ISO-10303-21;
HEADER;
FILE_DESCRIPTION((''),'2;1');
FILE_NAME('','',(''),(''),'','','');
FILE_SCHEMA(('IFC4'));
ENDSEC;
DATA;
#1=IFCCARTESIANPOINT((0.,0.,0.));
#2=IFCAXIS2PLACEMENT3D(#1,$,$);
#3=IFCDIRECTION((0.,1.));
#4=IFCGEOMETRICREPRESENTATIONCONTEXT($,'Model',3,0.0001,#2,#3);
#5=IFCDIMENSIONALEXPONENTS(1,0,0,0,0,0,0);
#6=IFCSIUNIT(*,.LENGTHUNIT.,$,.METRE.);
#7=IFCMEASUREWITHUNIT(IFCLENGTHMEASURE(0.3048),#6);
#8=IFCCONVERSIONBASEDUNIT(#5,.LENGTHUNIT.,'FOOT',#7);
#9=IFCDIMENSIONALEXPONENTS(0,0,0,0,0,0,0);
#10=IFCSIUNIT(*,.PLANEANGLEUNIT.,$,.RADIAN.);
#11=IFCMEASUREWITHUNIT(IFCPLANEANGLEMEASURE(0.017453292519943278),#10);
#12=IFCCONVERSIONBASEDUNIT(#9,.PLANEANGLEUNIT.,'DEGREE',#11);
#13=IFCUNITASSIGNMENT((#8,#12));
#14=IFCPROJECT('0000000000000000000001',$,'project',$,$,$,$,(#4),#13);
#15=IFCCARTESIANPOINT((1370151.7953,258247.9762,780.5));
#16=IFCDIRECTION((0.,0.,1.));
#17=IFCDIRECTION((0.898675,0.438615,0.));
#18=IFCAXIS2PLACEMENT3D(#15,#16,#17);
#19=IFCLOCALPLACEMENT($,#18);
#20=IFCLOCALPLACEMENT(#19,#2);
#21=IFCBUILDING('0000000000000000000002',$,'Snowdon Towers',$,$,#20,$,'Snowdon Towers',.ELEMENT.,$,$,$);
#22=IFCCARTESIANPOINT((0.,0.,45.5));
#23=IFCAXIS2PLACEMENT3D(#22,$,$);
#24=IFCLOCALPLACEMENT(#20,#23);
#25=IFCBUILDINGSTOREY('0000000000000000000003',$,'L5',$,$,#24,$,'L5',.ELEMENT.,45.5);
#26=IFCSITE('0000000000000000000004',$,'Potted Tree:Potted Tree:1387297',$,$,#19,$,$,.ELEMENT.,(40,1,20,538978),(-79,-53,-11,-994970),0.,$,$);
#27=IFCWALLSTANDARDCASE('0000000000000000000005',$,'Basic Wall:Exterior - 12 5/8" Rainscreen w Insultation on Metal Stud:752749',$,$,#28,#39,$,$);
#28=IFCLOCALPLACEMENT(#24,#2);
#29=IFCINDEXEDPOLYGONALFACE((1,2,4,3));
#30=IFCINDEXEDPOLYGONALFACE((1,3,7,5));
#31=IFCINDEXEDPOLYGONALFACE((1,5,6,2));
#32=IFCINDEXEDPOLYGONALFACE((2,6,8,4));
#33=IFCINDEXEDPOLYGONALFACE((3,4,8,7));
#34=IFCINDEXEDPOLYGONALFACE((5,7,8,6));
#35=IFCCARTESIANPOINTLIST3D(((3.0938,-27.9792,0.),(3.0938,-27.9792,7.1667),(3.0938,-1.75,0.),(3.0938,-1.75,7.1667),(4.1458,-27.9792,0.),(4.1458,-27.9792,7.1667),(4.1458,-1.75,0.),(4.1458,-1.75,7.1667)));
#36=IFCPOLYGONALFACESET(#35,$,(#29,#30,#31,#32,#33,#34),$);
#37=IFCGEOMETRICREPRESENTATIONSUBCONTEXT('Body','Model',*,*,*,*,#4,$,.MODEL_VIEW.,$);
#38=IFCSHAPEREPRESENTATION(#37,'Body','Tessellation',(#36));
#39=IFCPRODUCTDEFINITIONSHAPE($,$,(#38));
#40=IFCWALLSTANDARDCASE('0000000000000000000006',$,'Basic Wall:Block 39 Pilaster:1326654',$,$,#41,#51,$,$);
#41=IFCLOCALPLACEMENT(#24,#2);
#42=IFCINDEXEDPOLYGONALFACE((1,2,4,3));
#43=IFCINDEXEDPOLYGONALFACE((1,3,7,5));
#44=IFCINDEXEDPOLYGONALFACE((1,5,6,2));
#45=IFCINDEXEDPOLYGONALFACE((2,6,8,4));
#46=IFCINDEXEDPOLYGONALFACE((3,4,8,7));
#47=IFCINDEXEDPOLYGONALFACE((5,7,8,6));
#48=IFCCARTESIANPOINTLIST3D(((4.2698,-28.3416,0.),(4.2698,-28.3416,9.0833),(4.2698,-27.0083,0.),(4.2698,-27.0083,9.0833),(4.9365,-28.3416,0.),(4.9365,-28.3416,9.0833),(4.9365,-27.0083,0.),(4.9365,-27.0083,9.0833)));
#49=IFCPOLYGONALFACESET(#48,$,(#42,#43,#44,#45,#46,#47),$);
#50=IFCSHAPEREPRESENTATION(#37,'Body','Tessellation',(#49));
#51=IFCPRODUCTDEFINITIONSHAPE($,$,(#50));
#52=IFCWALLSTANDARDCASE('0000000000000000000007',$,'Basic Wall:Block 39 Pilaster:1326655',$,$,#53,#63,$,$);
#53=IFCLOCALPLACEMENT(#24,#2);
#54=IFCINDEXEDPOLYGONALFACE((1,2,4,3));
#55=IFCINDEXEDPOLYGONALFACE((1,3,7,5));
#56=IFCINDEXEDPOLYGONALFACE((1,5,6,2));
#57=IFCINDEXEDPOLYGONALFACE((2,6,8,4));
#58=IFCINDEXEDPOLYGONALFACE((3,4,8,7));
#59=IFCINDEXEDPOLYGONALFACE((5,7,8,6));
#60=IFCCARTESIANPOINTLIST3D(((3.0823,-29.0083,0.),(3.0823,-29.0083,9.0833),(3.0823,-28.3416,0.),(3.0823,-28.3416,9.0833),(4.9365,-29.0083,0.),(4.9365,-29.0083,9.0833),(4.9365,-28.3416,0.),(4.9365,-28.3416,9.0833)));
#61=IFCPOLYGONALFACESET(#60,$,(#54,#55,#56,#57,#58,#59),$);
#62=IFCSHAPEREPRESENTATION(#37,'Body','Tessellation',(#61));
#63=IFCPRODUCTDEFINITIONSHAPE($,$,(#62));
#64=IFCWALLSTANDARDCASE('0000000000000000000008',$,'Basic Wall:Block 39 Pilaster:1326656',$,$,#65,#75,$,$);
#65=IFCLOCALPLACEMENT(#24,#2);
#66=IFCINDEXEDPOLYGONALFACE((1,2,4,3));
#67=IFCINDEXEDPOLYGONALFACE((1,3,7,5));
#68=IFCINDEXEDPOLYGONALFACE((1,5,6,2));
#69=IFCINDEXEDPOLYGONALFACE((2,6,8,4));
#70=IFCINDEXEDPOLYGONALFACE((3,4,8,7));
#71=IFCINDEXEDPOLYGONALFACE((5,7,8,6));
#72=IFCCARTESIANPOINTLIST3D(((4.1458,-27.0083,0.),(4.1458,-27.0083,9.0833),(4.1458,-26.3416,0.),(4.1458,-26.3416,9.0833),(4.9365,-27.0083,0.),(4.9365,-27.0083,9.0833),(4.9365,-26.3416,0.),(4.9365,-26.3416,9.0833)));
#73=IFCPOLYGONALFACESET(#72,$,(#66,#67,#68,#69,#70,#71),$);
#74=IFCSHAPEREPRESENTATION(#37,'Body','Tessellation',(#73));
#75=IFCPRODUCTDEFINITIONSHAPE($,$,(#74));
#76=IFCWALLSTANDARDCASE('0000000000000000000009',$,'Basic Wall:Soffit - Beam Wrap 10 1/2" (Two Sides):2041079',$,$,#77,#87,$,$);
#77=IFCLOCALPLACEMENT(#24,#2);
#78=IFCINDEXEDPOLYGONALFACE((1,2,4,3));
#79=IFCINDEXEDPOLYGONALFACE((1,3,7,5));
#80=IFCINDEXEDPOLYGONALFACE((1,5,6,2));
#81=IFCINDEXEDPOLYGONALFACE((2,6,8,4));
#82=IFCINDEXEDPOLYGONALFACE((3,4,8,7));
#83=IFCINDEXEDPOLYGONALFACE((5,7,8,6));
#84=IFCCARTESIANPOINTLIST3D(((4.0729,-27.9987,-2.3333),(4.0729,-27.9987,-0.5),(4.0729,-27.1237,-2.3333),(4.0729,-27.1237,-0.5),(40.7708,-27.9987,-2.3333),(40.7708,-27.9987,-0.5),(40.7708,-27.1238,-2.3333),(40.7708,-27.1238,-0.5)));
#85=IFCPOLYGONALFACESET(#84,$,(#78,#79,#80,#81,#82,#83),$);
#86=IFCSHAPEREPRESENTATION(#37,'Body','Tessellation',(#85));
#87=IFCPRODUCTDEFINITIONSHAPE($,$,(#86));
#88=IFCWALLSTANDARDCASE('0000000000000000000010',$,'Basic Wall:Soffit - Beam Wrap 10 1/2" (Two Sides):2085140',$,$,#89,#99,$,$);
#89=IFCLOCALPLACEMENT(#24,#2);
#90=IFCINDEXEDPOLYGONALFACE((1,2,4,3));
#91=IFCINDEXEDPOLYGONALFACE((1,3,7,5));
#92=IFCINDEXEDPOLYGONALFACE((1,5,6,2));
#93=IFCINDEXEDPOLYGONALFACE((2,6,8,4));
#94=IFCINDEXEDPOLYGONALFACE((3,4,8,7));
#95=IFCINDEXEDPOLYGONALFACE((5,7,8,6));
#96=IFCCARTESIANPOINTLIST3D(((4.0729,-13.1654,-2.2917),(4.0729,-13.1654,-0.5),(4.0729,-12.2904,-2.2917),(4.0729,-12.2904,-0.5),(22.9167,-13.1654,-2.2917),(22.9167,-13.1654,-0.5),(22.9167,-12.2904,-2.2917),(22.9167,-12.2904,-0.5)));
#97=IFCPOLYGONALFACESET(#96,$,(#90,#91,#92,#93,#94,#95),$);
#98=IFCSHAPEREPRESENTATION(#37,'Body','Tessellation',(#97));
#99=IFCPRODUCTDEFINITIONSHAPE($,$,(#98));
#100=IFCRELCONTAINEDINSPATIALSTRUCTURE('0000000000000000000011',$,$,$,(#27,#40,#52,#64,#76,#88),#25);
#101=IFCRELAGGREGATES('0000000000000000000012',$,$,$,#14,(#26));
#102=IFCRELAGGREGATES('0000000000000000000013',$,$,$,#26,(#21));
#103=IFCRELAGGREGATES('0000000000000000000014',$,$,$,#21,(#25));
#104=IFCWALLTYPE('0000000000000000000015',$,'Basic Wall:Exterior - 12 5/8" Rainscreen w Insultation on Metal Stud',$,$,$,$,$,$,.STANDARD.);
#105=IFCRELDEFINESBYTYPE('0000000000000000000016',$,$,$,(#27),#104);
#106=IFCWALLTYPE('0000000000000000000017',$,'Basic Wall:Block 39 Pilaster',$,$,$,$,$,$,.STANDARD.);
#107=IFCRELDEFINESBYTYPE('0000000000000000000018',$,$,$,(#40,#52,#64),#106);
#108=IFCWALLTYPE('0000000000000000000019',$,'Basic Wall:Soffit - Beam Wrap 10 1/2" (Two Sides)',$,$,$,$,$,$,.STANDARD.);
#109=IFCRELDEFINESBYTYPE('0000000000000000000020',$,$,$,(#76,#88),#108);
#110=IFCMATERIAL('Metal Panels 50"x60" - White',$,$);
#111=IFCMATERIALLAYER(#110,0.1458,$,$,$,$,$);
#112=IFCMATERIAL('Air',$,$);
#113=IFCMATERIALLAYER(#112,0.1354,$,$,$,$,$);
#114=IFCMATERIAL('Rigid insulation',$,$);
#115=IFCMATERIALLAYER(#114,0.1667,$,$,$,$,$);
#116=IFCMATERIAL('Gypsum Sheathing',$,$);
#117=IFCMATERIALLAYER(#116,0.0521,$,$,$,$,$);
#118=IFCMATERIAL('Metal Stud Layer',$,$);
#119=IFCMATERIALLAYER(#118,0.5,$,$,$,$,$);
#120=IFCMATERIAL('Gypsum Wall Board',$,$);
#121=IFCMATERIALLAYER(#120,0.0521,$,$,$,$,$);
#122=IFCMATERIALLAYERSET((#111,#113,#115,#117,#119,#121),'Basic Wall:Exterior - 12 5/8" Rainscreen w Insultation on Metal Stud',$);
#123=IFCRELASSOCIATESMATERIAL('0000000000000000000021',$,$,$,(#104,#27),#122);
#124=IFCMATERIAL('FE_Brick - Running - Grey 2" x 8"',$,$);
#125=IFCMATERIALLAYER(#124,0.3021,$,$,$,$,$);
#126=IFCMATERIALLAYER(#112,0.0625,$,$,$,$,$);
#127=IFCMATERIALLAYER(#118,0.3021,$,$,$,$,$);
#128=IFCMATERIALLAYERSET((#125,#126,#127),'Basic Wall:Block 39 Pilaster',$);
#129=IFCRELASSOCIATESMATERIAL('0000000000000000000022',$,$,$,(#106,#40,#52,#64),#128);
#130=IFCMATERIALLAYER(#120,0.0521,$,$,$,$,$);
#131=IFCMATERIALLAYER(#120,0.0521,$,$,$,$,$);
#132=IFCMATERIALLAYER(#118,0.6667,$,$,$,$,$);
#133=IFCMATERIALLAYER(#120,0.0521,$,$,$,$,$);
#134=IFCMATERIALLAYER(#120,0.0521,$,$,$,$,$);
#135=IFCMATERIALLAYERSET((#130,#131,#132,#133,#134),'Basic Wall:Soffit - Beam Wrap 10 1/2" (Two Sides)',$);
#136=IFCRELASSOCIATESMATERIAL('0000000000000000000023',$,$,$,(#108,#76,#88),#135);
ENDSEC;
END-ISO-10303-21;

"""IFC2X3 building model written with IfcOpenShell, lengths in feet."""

from ifc_helpers import new_model, entity, si_unit, converted_unit, direction, frame, frame_2d, origin, place, context, subcontext, project, spatial, rectangle, extrude, material, layer, layer_set, layer_usage, type_object, element, save


model = new_model("IFC2X3")

# Units and contexts
model_context = context("Model", 3, precision=0.0001, world=origin(), true_north=direction((0.0, 1.0)))
body_context = subcontext(model_context, "Body", "Model", "MODEL_VIEW")
ifc_project = project(units=[converted_unit("LENGTHUNIT", "FOOT", entity("IfcLengthMeasure", 0.3048), si_unit("LENGTHUNIT", "METRE"), dimensions=[1, 0, 0, 0, 0, 0, 0]), converted_unit("PLANEANGLEUNIT", "DEGREE", entity("IfcPlaneAngleMeasure", 0.017453292519943278), si_unit("PLANEANGLEUNIT", "RADIAN"), dimensions=[0, 0, 0, 0, 0, 0, 0])], contexts=[model_context])

# Site, building, storey
site_placement = place(None, frame((1370151.7953, 258247.9762, 780.5), z_axis=(0.0, 0.0, 1.0), x_axis=(0.898675, 0.438615, 0.0)))
site = spatial("IfcSite", under=ifc_project, at=site_placement, Name="Potted Tree:Potted Tree:1387297", CompositionType="ELEMENT", RefLatitude=(40, 1, 20, 538978), RefLongitude=(-79, -53, -11, -994970), RefElevation=0.0)
building_placement = place(site_placement, origin())
building = spatial("IfcBuilding", under=site, at=building_placement, Name="Snowdon Towers", LongName="Snowdon Towers", CompositionType="ELEMENT")
storey_placement = place(building_placement, frame((0.0, 0.0, 45.5)))
storey = spatial("IfcBuildingStorey", under=building, at=storey_placement, Name="L5", LongName="L5", CompositionType="ELEMENT", Elevation=45.5)

# Walls
ifc_material_1 = material(Name="Metal Panels 50\"x60\" - White")
ifc_layer_1 = layer(ifc_material_1, 0.1458)
ifc_material_2 = material(Name="Air")
ifc_layer_2 = layer(ifc_material_2, 0.1354)
ifc_material_3 = material(Name="Rigid insulation")
ifc_layer_3 = layer(ifc_material_3, 0.1667)
ifc_material_4 = material(Name="Gypsum Sheathing")
ifc_layer_4 = layer(ifc_material_4, 0.0521)
ifc_material_5 = material(Name="Metal Stud Layer")
ifc_layer_5 = layer(ifc_material_5, 0.5)
ifc_material_6 = material(Name="Gypsum Wall Board")
ifc_layer_6 = layer(ifc_material_6, 0.0521)
ifc_layer_set_1 = layer_set([ifc_layer_1, ifc_layer_2, ifc_layer_3, ifc_layer_4, ifc_layer_5, ifc_layer_6], Name="Basic Wall:Exterior - 12 5/8\" Rainscreen w Insultation on Metal Stud")
ifc_layer_usage_1 = layer_usage(ifc_layer_set_1, "AXIS2", "POSITIVE", -0.526)
wall_type_1 = type_object("IfcWallType", Name="Basic Wall:Exterior - 12 5/8\" Rainscreen w Insultation on Metal Stud", PredefinedType="STANDARD", material=ifc_layer_set_1)
wall_1_placement = place(storey_placement, frame((3.6198, -27.9792, 0.0), z_axis=(0.0, 0.0, 1.0), x_axis=(0.0, 1.0, 0.0)))
element("IfcWallStandardCase", 1, at=wall_1_placement, inside=storey, type_object=wall_type_1, material=ifc_layer_usage_1, Name="Basic Wall:Exterior - 12 5/8\" Rainscreen w Insultation on Metal Stud:752749", context=body_context, shape_type="SweptSolid", body=[
    extrude(rectangle(XDim=26.2292, YDim=1.0521, at=frame_2d((13.1146, 0.0), x_axis=(-1.0, 0.0))), origin(), (0.0, 0.0, 1.0), 7.1667),
])
ifc_material_7 = material(Name="FE_Brick - Running - Grey 2\" x 8\"")
ifc_layer_7 = layer(ifc_material_7, 0.3021)
ifc_layer_8 = layer(ifc_material_2, 0.0625)
ifc_layer_9 = layer(ifc_material_5, 0.3021)
ifc_layer_set_2 = layer_set([ifc_layer_7, ifc_layer_8, ifc_layer_9], Name="Basic Wall:Block 39 Pilaster")
ifc_layer_usage_2 = layer_usage(ifc_layer_set_2, "AXIS2", "NEGATIVE", 0.3333)
wall_type_2 = type_object("IfcWallType", Name="Basic Wall:Block 39 Pilaster", PredefinedType="STANDARD", material=ifc_layer_set_2)
wall_2_placement = place(storey_placement, frame((4.6031, -27.0083, 0.0), z_axis=(0.0, 0.0, 1.0), x_axis=(0.0, -1.0, 0.0)))
element("IfcWallStandardCase", 2, at=wall_2_placement, inside=storey, type_object=wall_type_2, material=ifc_layer_usage_2, Name="Basic Wall:Block 39 Pilaster:1326654", context=body_context, shape_type="SweptSolid", body=[
    extrude(rectangle(XDim=1.3333, YDim=0.6667, at=frame_2d((0.6667, 0.0), x_axis=(-1.0, 0.0))), origin(), (0.0, 0.0, 1.0), 9.0833),
])
ifc_layer_usage_3 = layer_usage(ifc_layer_set_2, "AXIS2", "NEGATIVE", 0.3333)
wall_3_placement = place(storey_placement, frame((4.9365, -28.675, 0.0), z_axis=(0.0, 0.0, 1.0), x_axis=(-1.0, 0.0, 0.0)))
element("IfcWallStandardCase", 3, at=wall_3_placement, inside=storey, type_object=wall_type_2, material=ifc_layer_usage_3, Name="Basic Wall:Block 39 Pilaster:1326655", context=body_context, shape_type="SweptSolid", body=[
    extrude(rectangle(XDim=1.8542, YDim=0.6667, at=frame_2d((0.9271, 0.0), x_axis=(-1.0, 0.0))), origin(), (0.0, 0.0, 1.0), 9.0833),
])
ifc_layer_usage_4 = layer_usage(ifc_layer_set_2, "AXIS2", "POSITIVE", -0.3333)
wall_4_placement = place(storey_placement, frame((4.9365, -26.675, 0.0), z_axis=(0.0, 0.0, 1.0), x_axis=(-1.0, 0.0, 0.0)))
element("IfcWallStandardCase", 4, at=wall_4_placement, inside=storey, type_object=wall_type_2, material=ifc_layer_usage_4, Name="Basic Wall:Block 39 Pilaster:1326656", context=body_context, shape_type="SweptSolid", body=[
    extrude(rectangle(XDim=0.7906, YDim=0.6667, at=frame_2d((0.3953, 0.0), x_axis=(-1.0, 0.0))), origin(), (0.0, 0.0, 1.0), 9.0833),
])
ifc_layer_10 = layer(ifc_material_6, 0.0521)
ifc_layer_11 = layer(ifc_material_6, 0.0521)
ifc_layer_12 = layer(ifc_material_5, 0.6667)
ifc_layer_13 = layer(ifc_material_6, 0.0521)
ifc_layer_14 = layer(ifc_material_6, 0.0521)
ifc_layer_set_3 = layer_set([ifc_layer_10, ifc_layer_11, ifc_layer_12, ifc_layer_13, ifc_layer_14], Name="Basic Wall:Soffit - Beam Wrap 10 1/2\" (Two Sides)")
ifc_layer_usage_5 = layer_usage(ifc_layer_set_3, "AXIS2", "NEGATIVE", 0.4375)
wall_type_3 = type_object("IfcWallType", Name="Basic Wall:Soffit - Beam Wrap 10 1/2\" (Two Sides)", PredefinedType="STANDARD", material=ifc_layer_set_3)
wall_5_placement = place(storey_placement, frame((4.0729, -27.5613, -2.3333)))
element("IfcWallStandardCase", 5, at=wall_5_placement, inside=storey, type_object=wall_type_3, material=ifc_layer_usage_5, Name="Basic Wall:Soffit - Beam Wrap 10 1/2\" (Two Sides):2041079", context=body_context, shape_type="SweptSolid", body=[
    extrude(rectangle(XDim=36.6979, YDim=0.875, at=frame_2d((18.349, 0.0), x_axis=(-1.0, 0.0))), origin(), (0.0, 0.0, 1.0), 1.8333),
])
ifc_layer_usage_6 = layer_usage(ifc_layer_set_3, "AXIS2", "NEGATIVE", 0.4375)
wall_6_placement = place(storey_placement, frame((4.0729, -12.7279, -2.2917)))
element("IfcWallStandardCase", 6, at=wall_6_placement, inside=storey, type_object=wall_type_3, material=ifc_layer_usage_6, Name="Basic Wall:Soffit - Beam Wrap 10 1/2\" (Two Sides):2085140", context=body_context, shape_type="SweptSolid", body=[
    extrude(rectangle(XDim=18.8438, YDim=0.875, at=frame_2d((9.4219, 0.0), x_axis=(-1.0, 0.0))), origin(), (0.0, 0.0, 1.0), 1.7917),
])

save(model, "model.ifc")
